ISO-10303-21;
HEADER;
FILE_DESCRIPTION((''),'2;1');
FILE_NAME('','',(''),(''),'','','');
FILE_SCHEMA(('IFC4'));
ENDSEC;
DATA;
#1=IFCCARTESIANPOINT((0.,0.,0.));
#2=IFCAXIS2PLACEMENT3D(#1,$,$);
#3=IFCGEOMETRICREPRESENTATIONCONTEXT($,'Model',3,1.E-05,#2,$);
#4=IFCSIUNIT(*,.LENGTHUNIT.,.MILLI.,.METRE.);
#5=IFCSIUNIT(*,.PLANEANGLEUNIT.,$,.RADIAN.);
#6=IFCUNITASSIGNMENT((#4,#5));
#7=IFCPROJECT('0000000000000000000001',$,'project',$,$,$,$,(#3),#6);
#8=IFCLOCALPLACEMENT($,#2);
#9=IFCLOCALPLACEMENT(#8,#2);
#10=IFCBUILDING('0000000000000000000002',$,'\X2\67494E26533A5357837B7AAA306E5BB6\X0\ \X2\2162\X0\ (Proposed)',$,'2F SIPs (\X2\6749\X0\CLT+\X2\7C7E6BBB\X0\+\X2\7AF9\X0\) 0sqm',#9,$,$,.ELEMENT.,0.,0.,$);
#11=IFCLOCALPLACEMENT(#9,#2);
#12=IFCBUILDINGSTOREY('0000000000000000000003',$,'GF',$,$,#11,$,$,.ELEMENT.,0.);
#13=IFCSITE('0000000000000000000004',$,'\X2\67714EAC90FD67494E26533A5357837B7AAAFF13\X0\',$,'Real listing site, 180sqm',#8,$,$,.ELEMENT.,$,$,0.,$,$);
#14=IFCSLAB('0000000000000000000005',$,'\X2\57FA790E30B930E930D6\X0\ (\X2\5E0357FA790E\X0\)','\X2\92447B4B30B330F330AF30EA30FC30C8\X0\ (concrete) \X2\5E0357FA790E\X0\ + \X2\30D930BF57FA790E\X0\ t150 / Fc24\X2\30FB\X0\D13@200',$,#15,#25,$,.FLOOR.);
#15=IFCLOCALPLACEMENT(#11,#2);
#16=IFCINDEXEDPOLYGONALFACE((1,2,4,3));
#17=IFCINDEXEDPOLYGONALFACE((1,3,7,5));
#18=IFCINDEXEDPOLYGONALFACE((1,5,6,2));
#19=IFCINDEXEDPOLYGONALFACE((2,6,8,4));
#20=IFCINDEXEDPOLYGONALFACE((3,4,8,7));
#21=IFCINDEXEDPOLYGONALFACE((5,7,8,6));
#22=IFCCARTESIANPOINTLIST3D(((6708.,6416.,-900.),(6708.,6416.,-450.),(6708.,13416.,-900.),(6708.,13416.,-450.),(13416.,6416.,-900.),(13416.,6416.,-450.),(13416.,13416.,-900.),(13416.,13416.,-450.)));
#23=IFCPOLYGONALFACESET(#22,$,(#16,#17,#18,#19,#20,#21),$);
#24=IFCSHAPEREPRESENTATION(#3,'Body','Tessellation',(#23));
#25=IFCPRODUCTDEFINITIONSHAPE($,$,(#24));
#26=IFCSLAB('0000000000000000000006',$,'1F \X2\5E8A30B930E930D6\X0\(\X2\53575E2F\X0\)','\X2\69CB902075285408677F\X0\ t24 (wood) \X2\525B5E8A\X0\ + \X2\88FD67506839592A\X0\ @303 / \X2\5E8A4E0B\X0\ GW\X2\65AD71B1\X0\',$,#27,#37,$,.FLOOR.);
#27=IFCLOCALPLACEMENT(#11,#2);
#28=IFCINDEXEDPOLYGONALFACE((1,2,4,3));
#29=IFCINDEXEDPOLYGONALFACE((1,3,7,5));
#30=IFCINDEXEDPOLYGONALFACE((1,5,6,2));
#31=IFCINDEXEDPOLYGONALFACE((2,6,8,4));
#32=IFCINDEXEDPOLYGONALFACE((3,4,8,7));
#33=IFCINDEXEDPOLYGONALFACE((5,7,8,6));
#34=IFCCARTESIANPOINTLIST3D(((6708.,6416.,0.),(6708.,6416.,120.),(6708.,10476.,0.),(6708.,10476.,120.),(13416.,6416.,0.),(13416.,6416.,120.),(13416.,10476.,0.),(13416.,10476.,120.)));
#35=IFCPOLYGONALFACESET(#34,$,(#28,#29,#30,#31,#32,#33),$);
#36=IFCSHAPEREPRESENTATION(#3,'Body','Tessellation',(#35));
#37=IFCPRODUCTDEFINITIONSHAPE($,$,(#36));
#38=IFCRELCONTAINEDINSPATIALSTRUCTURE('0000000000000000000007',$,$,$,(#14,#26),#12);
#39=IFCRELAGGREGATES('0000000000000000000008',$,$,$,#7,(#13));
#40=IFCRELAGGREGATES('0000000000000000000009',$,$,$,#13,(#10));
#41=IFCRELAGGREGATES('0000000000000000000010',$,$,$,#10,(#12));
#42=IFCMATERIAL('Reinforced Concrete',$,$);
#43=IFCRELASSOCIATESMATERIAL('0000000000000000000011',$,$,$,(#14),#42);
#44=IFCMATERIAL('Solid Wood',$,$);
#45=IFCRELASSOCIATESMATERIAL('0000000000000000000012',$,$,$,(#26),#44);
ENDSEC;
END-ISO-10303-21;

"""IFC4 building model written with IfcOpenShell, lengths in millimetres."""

from ifc_helpers import new_model, si_unit, frame, frame_2d, origin, place, context, project, spatial, rectangle, extrude, material, element, save


model = new_model("IFC4")

# Units and contexts
model_context = context("Model", 3, precision=1e-05, world=origin())
ifc_project = project(units=[si_unit("LENGTHUNIT", "METRE", prefix="MILLI"), si_unit("PLANEANGLEUNIT", "RADIAN")], contexts=[model_context])

# Site, building, storey
site_placement = place(None, origin())
site = spatial("IfcSite", under=ifc_project, at=site_placement, Name="東京都杉並区南荻窪３", ObjectType="Real listing site, 180sqm", CompositionType="ELEMENT", RefElevation=0.0)
building_placement = place(site_placement, origin())
building = spatial("IfcBuilding", under=site, at=building_placement, Name="杉並区南荻窪の家 Ⅲ (Proposed)", ObjectType="2F SIPs (杉CLT+籾殻+竹) 0sqm", CompositionType="ELEMENT", ElevationOfRefHeight=0.0, ElevationOfTerrain=0.0)
storey_placement = place(building_placement, origin())
storey = spatial("IfcBuildingStorey", under=building, at=storey_placement, Name="GF", CompositionType="ELEMENT", Elevation=0.0)

# Slabs
ifc_material_1 = material(Name="Reinforced Concrete")
slab_1_placement = place(storey_placement, frame((3354.0, 3208.0, -450.0)))
element("IfcSlab", 1, at=slab_1_placement, inside=storey, material=ifc_material_1, Name="基礎スラブ (布基礎)", Description="鉄筋コンクリート (concrete) 布基礎 + ベタ基礎 t150 / Fc24・D13@200", PredefinedType="FLOOR", context=model_context, shape_type="SweptSolid", body=[
    extrude(rectangle(XDim=6708.0, YDim=7000.0, at=frame_2d((3354.0, 3500.0))), frame((3354.0, 3208.0, -450.0)), (0.0, 0.0, 1.0), 450.0),
])
ifc_material_2 = material(Name="Solid Wood")
slab_2_placement = place(storey_placement, frame((3354.0, 3208.0, 0.0)))
element("IfcSlab", 2, at=slab_2_placement, inside=storey, material=ifc_material_2, Name="1F 床スラブ(南帯)", Description="構造用合板 t24 (wood) 剛床 + 製材根太 @303 / 床下 GW断熱", PredefinedType="FLOOR", context=model_context, shape_type="SweptSolid", body=[
    extrude(rectangle(XDim=6708.0, YDim=4060.0, at=frame_2d((3354.0, 2030.0))), frame((3354.0, 3208.0, 0.0)), (0.0, 0.0, 1.0), 120.0),
])

save(model, "model.ifc")
